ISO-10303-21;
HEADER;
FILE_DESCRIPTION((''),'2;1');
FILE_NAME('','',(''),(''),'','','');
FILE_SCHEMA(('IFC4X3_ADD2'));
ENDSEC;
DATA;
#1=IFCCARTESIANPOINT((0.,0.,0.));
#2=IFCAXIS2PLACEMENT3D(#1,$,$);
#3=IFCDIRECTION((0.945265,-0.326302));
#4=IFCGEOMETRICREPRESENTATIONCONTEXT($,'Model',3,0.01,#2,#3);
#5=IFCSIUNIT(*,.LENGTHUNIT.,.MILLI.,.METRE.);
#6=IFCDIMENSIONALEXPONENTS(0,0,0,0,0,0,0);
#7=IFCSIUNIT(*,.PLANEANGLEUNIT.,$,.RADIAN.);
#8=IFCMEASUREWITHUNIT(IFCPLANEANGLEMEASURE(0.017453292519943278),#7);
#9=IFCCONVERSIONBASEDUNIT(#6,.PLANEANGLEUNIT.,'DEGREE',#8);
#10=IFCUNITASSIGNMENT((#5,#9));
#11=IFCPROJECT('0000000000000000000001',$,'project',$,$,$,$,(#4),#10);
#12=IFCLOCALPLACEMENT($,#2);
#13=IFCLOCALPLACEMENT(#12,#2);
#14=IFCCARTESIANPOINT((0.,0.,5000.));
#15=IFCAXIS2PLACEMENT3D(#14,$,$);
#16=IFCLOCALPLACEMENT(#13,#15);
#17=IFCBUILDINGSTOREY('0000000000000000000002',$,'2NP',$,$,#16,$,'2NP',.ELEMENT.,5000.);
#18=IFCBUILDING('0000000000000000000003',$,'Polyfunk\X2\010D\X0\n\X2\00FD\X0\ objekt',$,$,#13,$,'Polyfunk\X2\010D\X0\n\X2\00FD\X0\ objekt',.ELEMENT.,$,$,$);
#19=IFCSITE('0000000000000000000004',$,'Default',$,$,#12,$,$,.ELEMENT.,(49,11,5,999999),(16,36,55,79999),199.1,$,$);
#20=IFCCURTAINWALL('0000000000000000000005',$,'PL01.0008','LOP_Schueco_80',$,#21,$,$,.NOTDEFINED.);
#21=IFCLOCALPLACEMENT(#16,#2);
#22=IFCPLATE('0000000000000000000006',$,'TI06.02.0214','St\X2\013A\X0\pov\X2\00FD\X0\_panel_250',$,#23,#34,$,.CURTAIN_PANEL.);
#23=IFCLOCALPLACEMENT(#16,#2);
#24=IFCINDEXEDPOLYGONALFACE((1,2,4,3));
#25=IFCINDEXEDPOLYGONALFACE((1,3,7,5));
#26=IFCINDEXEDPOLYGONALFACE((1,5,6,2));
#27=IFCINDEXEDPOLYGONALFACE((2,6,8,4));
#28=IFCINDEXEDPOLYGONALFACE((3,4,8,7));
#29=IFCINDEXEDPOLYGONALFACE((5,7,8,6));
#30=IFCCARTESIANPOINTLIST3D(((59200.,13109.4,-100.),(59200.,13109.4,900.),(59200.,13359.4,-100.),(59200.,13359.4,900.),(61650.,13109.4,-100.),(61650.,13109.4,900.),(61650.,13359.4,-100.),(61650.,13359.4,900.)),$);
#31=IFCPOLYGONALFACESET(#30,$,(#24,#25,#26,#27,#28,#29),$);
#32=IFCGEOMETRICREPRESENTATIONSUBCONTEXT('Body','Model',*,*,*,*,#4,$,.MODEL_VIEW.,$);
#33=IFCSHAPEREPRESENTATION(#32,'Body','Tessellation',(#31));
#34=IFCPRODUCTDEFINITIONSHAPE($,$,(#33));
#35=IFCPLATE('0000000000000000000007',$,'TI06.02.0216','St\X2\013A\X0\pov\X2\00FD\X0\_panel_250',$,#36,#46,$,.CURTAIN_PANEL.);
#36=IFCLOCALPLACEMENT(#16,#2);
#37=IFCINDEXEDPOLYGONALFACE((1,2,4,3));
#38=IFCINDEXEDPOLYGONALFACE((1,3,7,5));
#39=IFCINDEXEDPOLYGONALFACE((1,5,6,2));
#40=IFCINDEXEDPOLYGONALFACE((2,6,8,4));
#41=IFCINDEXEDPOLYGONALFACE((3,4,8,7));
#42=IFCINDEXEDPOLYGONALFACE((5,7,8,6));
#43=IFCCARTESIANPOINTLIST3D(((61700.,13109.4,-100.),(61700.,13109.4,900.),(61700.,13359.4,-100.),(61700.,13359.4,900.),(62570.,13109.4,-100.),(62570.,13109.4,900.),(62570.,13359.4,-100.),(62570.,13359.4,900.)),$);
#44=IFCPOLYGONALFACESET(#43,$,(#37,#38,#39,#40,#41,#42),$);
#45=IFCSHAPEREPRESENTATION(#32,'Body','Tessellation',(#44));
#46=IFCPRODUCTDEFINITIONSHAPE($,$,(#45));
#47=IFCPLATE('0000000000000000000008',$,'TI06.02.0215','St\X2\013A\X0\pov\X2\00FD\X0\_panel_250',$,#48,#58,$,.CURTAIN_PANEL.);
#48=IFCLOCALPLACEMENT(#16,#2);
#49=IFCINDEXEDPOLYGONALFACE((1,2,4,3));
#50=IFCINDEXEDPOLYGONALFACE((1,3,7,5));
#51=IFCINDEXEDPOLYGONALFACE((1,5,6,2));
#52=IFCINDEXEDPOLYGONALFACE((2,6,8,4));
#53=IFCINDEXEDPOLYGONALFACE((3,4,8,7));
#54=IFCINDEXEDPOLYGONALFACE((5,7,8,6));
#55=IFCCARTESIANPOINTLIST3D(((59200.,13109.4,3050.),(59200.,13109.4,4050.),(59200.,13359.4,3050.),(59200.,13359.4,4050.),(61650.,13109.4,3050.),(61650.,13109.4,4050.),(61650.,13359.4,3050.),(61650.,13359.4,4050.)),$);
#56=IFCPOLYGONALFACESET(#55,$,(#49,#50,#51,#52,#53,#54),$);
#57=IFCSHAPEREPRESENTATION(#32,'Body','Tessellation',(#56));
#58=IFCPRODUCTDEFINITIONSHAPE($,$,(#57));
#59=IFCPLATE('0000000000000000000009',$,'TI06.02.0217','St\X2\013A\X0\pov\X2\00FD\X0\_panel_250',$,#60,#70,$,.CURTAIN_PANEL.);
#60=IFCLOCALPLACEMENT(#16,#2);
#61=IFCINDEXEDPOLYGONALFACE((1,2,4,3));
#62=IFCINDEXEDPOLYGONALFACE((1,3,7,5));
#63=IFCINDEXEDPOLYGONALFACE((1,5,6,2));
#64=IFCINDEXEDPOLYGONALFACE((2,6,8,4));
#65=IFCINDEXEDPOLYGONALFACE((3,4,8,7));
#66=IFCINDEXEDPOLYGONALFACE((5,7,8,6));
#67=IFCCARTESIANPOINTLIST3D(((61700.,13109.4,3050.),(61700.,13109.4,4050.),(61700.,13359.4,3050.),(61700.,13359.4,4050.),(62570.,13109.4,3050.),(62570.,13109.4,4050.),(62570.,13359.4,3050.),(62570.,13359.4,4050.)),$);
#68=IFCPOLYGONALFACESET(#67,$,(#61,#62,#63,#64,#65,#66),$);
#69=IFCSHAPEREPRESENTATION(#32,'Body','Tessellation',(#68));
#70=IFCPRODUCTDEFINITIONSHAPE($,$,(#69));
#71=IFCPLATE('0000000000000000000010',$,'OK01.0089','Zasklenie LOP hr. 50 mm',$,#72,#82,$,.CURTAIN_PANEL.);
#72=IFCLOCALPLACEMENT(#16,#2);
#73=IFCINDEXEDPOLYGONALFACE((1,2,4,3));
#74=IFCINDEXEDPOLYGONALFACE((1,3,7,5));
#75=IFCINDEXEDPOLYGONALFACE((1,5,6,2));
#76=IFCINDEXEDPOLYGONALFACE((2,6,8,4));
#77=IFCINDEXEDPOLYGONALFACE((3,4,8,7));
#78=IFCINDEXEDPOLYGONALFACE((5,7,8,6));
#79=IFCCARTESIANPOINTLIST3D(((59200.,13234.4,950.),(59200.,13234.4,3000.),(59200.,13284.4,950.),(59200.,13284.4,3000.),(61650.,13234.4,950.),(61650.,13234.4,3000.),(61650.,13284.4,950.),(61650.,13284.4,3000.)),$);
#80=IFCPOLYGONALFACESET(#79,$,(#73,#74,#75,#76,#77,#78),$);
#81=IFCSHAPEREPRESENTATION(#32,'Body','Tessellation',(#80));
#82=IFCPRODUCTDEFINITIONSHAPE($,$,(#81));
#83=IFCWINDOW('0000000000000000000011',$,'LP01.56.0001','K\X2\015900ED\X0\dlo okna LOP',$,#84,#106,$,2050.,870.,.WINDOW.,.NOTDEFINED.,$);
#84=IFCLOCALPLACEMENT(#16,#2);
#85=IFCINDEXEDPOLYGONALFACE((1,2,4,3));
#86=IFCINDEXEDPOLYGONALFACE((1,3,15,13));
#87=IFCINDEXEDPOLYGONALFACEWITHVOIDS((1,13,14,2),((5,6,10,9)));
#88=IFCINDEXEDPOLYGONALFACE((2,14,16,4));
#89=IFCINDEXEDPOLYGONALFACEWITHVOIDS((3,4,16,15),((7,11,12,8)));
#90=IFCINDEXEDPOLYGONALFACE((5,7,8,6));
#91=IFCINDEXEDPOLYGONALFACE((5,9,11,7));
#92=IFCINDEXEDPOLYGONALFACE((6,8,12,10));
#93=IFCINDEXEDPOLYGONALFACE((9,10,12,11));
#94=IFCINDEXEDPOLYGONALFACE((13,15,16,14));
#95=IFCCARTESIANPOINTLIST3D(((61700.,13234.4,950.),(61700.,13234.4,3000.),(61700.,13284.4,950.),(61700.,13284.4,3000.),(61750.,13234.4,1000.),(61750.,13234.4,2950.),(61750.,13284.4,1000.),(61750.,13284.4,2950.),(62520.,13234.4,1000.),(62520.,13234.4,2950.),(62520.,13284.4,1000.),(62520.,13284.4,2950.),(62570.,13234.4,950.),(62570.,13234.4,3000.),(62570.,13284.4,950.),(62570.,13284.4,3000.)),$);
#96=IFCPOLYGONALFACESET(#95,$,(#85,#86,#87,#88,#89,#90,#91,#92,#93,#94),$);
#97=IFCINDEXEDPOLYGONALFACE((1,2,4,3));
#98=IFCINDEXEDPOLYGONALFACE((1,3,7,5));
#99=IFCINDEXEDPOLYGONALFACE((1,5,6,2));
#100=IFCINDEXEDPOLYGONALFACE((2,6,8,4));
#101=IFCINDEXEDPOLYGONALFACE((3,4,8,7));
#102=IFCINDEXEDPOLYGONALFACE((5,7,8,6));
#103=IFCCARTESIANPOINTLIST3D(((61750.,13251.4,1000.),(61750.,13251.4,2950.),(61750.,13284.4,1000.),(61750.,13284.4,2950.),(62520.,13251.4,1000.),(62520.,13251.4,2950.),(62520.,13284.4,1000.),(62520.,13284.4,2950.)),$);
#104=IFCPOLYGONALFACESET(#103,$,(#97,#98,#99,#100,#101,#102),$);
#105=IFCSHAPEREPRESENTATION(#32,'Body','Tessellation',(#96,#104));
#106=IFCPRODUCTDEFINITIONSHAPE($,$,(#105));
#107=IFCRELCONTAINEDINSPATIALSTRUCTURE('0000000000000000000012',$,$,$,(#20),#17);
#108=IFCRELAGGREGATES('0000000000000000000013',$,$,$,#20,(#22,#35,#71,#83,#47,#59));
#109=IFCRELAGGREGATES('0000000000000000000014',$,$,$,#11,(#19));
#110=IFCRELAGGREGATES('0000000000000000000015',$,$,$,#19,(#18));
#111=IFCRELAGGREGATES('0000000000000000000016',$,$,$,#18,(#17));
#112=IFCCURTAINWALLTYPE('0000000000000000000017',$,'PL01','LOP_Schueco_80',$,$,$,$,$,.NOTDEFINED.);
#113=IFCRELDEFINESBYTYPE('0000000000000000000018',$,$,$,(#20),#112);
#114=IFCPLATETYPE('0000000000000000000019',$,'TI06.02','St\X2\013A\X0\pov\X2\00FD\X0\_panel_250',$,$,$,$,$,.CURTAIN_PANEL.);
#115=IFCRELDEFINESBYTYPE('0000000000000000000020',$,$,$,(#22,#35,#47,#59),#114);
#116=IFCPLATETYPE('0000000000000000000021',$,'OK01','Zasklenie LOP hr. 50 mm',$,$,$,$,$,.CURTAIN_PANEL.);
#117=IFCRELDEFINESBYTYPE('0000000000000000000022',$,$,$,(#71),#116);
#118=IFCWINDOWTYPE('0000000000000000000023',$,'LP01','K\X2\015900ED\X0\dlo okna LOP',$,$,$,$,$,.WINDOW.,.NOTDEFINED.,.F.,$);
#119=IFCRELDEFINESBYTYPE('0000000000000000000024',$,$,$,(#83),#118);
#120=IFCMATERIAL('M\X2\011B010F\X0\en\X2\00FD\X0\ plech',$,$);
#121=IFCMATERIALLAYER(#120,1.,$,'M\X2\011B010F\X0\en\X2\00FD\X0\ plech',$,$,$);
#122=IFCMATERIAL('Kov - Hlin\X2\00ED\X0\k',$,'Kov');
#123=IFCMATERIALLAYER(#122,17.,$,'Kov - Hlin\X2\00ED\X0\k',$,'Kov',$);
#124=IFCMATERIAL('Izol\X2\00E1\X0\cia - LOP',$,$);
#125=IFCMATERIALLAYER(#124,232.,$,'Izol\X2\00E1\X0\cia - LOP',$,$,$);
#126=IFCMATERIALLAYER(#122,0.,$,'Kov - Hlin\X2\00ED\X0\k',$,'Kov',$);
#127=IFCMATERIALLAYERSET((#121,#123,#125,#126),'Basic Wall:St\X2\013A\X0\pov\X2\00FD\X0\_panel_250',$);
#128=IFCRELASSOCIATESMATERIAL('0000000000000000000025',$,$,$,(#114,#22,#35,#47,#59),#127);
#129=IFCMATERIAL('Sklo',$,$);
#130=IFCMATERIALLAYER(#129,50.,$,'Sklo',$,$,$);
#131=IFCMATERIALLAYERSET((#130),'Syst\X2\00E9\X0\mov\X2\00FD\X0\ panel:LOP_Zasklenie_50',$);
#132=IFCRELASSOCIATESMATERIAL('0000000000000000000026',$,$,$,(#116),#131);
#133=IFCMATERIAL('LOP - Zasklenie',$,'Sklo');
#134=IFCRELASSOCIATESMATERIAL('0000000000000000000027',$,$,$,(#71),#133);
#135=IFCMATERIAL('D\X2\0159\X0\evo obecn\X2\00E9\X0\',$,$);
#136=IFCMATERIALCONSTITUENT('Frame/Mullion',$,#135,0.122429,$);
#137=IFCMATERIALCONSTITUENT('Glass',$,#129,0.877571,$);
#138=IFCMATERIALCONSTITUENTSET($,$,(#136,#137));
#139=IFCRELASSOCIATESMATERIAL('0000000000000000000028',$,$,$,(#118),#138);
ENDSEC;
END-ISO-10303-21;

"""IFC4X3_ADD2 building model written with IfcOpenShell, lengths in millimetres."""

from ifc_helpers import new_model, entity, si_unit, converted_unit, direction, frame, frame_2d, origin, origin_2d_with_axis, place, context, subcontext, project, spatial, polyline, rectangle, outline, extrude, source, transform, mapped, material, layer, layer_set, layer_usage, constituent, constituent_set, type_object, type_shapes, element, aggregate, save


model = new_model("IFC4X3_ADD2")

# Units and contexts
model_context = context("Model", 3, precision=0.01, world=origin(), true_north=direction((0.945265, -0.326302)))
body_context = subcontext(model_context, "Body", "Model", "MODEL_VIEW")
ifc_project = project(units=[si_unit("LENGTHUNIT", "METRE", prefix="MILLI"), converted_unit("PLANEANGLEUNIT", "DEGREE", entity("IfcPlaneAngleMeasure", 0.017453292519943278), si_unit("PLANEANGLEUNIT", "RADIAN"), dimensions=[0, 0, 0, 0, 0, 0, 0])], contexts=[model_context])

# Site, building, storey
site_placement = place(None, origin())
site = spatial("IfcSite", under=ifc_project, at=site_placement, Name="Default", CompositionType="ELEMENT", RefLatitude=(49, 11, 5, 999999), RefLongitude=(16, 36, 55, 79999), RefElevation=199.1)
building_placement = place(site_placement, origin())
building = spatial("IfcBuilding", under=site, at=building_placement, Name="Polyfunkčný objekt", LongName="Polyfunkčný objekt", CompositionType="ELEMENT")
storey_placement = place(building_placement, frame((0.0, 0.0, 5000.0)))
storey = spatial("IfcBuildingStorey", under=building, at=storey_placement, Name="2NP", LongName="2NP", CompositionType="ELEMENT", Elevation=5000.0)

# Curtain wall, plates, window
curtain_wall_type = type_object("IfcCurtainWallType", Name="PL01", Description="LOP_Schueco_80", PredefinedType="NOTDEFINED")
curtain_wall_placement = place(storey_placement, frame((0.0, 0.0, -5000.0)))
curtain_wall = element("IfcCurtainWall", 1, at=curtain_wall_placement, inside=storey, type_object=curtain_wall_type, Name="PL01.0008", Description="LOP_Schueco_80", PredefinedType="NOTDEFINED")
ifc_material_1 = material(Name="Měďený plech")
ifc_layer_1 = layer(ifc_material_1, 1.0, Name="Měďený plech")
ifc_material_2 = material(Name="Kov - Hliník", Category="Kov")
ifc_layer_2 = layer(ifc_material_2, 17.0, Name="Kov - Hliník", Category="Kov")
ifc_material_3 = material(Name="Izolácia - LOP")
ifc_layer_3 = layer(ifc_material_3, 232.0, Name="Izolácia - LOP")
ifc_layer_4 = layer(ifc_material_2, 0.0, Name="Kov - Hliník", Category="Kov")
ifc_layer_set_1 = layer_set([ifc_layer_1, ifc_layer_2, ifc_layer_3, ifc_layer_4], Name="Basic Wall:Stĺpový_panel_250")
ifc_layer_usage_1 = layer_usage(ifc_layer_set_1, "AXIS2", "NEGATIVE", 125.0)
plate_type_1 = type_object("IfcPlateType", Name="TI06.02", Description="Stĺpový_panel_250", PredefinedType="CURTAIN_PANEL", material=ifc_layer_set_1)
plate_1_placement = place(storey_placement, frame((59200.0, 13234.4, -100.0)))
plate_1 = element("IfcPlate", 2, at=plate_1_placement, type_object=plate_type_1, material=ifc_layer_usage_1, Name="TI06.02.0214", Description="Stĺpový_panel_250", PredefinedType="CURTAIN_PANEL", context=body_context, shape_type="SweptSolid", body=[
    extrude(rectangle(XDim=250.0, YDim=2450.0, at=frame_2d((0.0, 0.0), x_axis=(1.0, 0.0))), frame((1225.0, 0.0, 0.0), z_axis=(0.0, 0.0, 1.0), x_axis=(0.0, 1.0, 0.0)), (0.0, 0.0, 1.0), 1000.0),
])
ifc_layer_usage_2 = layer_usage(ifc_layer_set_1, "AXIS2", "NEGATIVE", 125.0)
plate_2_placement = place(storey_placement, frame((61700.0, 13234.4, -100.0)))
plate_2 = element("IfcPlate", 3, at=plate_2_placement, type_object=plate_type_1, material=ifc_layer_usage_2, Name="TI06.02.0216", Description="Stĺpový_panel_250", PredefinedType="CURTAIN_PANEL", context=body_context, shape_type="SweptSolid", body=[
    extrude(rectangle(XDim=250.0, YDim=870.0, at=frame_2d((0.0, 0.0), x_axis=(1.0, 0.0))), frame((435.0, 0.0, 0.0), z_axis=(0.0, 0.0, 1.0), x_axis=(0.0, 1.0, 0.0)), (0.0, 0.0, 1.0), 1000.0),
])
ifc_layer_usage_3 = layer_usage(ifc_layer_set_1, "AXIS2", "NEGATIVE", 125.0)
plate_3_placement = place(storey_placement, frame((59200.0, 13234.4, 3050.0)))
plate_3 = element("IfcPlate", 4, at=plate_3_placement, type_object=plate_type_1, material=ifc_layer_usage_3, Name="TI06.02.0215", Description="Stĺpový_panel_250", PredefinedType="CURTAIN_PANEL", context=body_context, shape_type="SweptSolid", body=[
    extrude(rectangle(XDim=250.0, YDim=2450.0, at=frame_2d((0.0, 0.0), x_axis=(1.0, 0.0))), frame((1225.0, 0.0, 0.0), z_axis=(0.0, 0.0, 1.0), x_axis=(0.0, 1.0, 0.0)), (0.0, 0.0, 1.0), 1000.0),
])
ifc_layer_usage_4 = layer_usage(ifc_layer_set_1, "AXIS2", "NEGATIVE", 125.0)
plate_4_placement = place(storey_placement, frame((61700.0, 13234.4, 3050.0)))
plate_4 = element("IfcPlate", 5, at=plate_4_placement, type_object=plate_type_1, material=ifc_layer_usage_4, Name="TI06.02.0217", Description="Stĺpový_panel_250", PredefinedType="CURTAIN_PANEL", context=body_context, shape_type="SweptSolid", body=[
    extrude(rectangle(XDim=250.0, YDim=870.0, at=frame_2d((0.0, 0.0), x_axis=(1.0, 0.0))), frame((435.0, 0.0, 0.0), z_axis=(0.0, 0.0, 1.0), x_axis=(0.0, 1.0, 0.0)), (0.0, 0.0, 1.0), 1000.0),
])
ifc_material_4 = material(Name="LOP - Zasklenie", Category="Sklo")
ifc_material_5 = material(Name="Sklo")
ifc_layer_5 = layer(ifc_material_5, 50.0, Name="Sklo")
ifc_layer_set_2 = layer_set([ifc_layer_5], Name="Systémový panel:LOP_Zasklenie_50")
plate_type_2 = type_object("IfcPlateType", Name="OK01", Description="Zasklenie LOP hr. 50 mm", PredefinedType="CURTAIN_PANEL", material=ifc_layer_set_2)
shared_shape_1 = source(origin(), body_context, "Body", "SweptSolid", [
    extrude(rectangle(XDim=50.0, YDim=2450.0, at=origin_2d_with_axis()), frame((0.0, 25.0, 0.0), z_axis=(0.0, 0.0, 1.0), x_axis=(0.0, 1.0, 0.0)), (0.0, 0.0, 1.0), 2050.0),
])
type_shapes(plate_type_2, [shared_shape_1])
plate_5_placement = place(curtain_wall_placement, frame((60425.0, 13234.4, 5950.0)))
plate_5 = element("IfcPlate", 6, at=plate_5_placement, type_object=plate_type_2, material=ifc_material_4, Name="OK01.0089", Description="Zasklenie LOP hr. 50 mm", PredefinedType="CURTAIN_PANEL", context=body_context, shape_type="MappedRepresentation", body=[
    mapped(shared_shape_1, transform((0.0, 0.0, 0.0), scale=1.0)),
])
ifc_material_6 = material(Name="Dřevo obecné")
ifc_constituent_1 = constituent(ifc_material_6, Name="Frame/Mullion", fraction=0.122429)
ifc_constituent_2 = constituent(ifc_material_5, Name="Glass", fraction=0.877571)
ifc_constituent_set = constituent_set(constituents=[ifc_constituent_1, ifc_constituent_2])
window_type = type_object("IfcWindowType", Name="LP01", Description="Křídlo okna LOP", ParameterTakesPrecedence=False, PartitioningType="NOTDEFINED", PredefinedType="WINDOW", material=ifc_constituent_set)
shared_shape_2 = source(origin(), body_context, "Body", "SweptSolid", [
    extrude(outline(polyline([(-1025.0, -435.0), (1025.0, -435.0), (1025.0, 435.0), (-1025.0, 435.0), (-1025.0, -435.0)]), holes=[polyline([(-975.0, -385.0), (-975.0, 385.0), (975.0, 385.0), (975.0, -385.0), (-975.0, -385.0)])]), frame((0.0, 0.0, 1025.0), z_axis=(0.0, 1.0, 0.0), x_axis=(0.0, 0.0, -1.0)), (0.0, 0.0, 1.0), 50.0),
    extrude(rectangle(XDim=33.0, YDim=770.0, at=origin_2d_with_axis()), frame((0.0, 33.5, 50.0), z_axis=(0.0, 0.0, 1.0), x_axis=(0.0, -1.0, 0.0)), (0.0, 0.0, 1.0), 1950.0),
])
type_shapes(window_type, [shared_shape_2])
window_placement = place(curtain_wall_placement, frame((62135.0, 13234.4, 5950.0)))
window = element("IfcWindow", 7, at=window_placement, type_object=window_type, Name="LP01.56.0001", Description="Křídlo okna LOP", OverallHeight=2050.0, OverallWidth=870.0, PartitioningType="NOTDEFINED", PredefinedType="WINDOW", context=body_context, shape_type="MappedRepresentation", body=[
    mapped(shared_shape_2, transform((0.0, 0.0, 0.0), scale=1.0)),
])
aggregate(curtain_wall, [plate_1, plate_2, plate_5, window, plate_3, plate_4])

save(model, "model.ifc")
